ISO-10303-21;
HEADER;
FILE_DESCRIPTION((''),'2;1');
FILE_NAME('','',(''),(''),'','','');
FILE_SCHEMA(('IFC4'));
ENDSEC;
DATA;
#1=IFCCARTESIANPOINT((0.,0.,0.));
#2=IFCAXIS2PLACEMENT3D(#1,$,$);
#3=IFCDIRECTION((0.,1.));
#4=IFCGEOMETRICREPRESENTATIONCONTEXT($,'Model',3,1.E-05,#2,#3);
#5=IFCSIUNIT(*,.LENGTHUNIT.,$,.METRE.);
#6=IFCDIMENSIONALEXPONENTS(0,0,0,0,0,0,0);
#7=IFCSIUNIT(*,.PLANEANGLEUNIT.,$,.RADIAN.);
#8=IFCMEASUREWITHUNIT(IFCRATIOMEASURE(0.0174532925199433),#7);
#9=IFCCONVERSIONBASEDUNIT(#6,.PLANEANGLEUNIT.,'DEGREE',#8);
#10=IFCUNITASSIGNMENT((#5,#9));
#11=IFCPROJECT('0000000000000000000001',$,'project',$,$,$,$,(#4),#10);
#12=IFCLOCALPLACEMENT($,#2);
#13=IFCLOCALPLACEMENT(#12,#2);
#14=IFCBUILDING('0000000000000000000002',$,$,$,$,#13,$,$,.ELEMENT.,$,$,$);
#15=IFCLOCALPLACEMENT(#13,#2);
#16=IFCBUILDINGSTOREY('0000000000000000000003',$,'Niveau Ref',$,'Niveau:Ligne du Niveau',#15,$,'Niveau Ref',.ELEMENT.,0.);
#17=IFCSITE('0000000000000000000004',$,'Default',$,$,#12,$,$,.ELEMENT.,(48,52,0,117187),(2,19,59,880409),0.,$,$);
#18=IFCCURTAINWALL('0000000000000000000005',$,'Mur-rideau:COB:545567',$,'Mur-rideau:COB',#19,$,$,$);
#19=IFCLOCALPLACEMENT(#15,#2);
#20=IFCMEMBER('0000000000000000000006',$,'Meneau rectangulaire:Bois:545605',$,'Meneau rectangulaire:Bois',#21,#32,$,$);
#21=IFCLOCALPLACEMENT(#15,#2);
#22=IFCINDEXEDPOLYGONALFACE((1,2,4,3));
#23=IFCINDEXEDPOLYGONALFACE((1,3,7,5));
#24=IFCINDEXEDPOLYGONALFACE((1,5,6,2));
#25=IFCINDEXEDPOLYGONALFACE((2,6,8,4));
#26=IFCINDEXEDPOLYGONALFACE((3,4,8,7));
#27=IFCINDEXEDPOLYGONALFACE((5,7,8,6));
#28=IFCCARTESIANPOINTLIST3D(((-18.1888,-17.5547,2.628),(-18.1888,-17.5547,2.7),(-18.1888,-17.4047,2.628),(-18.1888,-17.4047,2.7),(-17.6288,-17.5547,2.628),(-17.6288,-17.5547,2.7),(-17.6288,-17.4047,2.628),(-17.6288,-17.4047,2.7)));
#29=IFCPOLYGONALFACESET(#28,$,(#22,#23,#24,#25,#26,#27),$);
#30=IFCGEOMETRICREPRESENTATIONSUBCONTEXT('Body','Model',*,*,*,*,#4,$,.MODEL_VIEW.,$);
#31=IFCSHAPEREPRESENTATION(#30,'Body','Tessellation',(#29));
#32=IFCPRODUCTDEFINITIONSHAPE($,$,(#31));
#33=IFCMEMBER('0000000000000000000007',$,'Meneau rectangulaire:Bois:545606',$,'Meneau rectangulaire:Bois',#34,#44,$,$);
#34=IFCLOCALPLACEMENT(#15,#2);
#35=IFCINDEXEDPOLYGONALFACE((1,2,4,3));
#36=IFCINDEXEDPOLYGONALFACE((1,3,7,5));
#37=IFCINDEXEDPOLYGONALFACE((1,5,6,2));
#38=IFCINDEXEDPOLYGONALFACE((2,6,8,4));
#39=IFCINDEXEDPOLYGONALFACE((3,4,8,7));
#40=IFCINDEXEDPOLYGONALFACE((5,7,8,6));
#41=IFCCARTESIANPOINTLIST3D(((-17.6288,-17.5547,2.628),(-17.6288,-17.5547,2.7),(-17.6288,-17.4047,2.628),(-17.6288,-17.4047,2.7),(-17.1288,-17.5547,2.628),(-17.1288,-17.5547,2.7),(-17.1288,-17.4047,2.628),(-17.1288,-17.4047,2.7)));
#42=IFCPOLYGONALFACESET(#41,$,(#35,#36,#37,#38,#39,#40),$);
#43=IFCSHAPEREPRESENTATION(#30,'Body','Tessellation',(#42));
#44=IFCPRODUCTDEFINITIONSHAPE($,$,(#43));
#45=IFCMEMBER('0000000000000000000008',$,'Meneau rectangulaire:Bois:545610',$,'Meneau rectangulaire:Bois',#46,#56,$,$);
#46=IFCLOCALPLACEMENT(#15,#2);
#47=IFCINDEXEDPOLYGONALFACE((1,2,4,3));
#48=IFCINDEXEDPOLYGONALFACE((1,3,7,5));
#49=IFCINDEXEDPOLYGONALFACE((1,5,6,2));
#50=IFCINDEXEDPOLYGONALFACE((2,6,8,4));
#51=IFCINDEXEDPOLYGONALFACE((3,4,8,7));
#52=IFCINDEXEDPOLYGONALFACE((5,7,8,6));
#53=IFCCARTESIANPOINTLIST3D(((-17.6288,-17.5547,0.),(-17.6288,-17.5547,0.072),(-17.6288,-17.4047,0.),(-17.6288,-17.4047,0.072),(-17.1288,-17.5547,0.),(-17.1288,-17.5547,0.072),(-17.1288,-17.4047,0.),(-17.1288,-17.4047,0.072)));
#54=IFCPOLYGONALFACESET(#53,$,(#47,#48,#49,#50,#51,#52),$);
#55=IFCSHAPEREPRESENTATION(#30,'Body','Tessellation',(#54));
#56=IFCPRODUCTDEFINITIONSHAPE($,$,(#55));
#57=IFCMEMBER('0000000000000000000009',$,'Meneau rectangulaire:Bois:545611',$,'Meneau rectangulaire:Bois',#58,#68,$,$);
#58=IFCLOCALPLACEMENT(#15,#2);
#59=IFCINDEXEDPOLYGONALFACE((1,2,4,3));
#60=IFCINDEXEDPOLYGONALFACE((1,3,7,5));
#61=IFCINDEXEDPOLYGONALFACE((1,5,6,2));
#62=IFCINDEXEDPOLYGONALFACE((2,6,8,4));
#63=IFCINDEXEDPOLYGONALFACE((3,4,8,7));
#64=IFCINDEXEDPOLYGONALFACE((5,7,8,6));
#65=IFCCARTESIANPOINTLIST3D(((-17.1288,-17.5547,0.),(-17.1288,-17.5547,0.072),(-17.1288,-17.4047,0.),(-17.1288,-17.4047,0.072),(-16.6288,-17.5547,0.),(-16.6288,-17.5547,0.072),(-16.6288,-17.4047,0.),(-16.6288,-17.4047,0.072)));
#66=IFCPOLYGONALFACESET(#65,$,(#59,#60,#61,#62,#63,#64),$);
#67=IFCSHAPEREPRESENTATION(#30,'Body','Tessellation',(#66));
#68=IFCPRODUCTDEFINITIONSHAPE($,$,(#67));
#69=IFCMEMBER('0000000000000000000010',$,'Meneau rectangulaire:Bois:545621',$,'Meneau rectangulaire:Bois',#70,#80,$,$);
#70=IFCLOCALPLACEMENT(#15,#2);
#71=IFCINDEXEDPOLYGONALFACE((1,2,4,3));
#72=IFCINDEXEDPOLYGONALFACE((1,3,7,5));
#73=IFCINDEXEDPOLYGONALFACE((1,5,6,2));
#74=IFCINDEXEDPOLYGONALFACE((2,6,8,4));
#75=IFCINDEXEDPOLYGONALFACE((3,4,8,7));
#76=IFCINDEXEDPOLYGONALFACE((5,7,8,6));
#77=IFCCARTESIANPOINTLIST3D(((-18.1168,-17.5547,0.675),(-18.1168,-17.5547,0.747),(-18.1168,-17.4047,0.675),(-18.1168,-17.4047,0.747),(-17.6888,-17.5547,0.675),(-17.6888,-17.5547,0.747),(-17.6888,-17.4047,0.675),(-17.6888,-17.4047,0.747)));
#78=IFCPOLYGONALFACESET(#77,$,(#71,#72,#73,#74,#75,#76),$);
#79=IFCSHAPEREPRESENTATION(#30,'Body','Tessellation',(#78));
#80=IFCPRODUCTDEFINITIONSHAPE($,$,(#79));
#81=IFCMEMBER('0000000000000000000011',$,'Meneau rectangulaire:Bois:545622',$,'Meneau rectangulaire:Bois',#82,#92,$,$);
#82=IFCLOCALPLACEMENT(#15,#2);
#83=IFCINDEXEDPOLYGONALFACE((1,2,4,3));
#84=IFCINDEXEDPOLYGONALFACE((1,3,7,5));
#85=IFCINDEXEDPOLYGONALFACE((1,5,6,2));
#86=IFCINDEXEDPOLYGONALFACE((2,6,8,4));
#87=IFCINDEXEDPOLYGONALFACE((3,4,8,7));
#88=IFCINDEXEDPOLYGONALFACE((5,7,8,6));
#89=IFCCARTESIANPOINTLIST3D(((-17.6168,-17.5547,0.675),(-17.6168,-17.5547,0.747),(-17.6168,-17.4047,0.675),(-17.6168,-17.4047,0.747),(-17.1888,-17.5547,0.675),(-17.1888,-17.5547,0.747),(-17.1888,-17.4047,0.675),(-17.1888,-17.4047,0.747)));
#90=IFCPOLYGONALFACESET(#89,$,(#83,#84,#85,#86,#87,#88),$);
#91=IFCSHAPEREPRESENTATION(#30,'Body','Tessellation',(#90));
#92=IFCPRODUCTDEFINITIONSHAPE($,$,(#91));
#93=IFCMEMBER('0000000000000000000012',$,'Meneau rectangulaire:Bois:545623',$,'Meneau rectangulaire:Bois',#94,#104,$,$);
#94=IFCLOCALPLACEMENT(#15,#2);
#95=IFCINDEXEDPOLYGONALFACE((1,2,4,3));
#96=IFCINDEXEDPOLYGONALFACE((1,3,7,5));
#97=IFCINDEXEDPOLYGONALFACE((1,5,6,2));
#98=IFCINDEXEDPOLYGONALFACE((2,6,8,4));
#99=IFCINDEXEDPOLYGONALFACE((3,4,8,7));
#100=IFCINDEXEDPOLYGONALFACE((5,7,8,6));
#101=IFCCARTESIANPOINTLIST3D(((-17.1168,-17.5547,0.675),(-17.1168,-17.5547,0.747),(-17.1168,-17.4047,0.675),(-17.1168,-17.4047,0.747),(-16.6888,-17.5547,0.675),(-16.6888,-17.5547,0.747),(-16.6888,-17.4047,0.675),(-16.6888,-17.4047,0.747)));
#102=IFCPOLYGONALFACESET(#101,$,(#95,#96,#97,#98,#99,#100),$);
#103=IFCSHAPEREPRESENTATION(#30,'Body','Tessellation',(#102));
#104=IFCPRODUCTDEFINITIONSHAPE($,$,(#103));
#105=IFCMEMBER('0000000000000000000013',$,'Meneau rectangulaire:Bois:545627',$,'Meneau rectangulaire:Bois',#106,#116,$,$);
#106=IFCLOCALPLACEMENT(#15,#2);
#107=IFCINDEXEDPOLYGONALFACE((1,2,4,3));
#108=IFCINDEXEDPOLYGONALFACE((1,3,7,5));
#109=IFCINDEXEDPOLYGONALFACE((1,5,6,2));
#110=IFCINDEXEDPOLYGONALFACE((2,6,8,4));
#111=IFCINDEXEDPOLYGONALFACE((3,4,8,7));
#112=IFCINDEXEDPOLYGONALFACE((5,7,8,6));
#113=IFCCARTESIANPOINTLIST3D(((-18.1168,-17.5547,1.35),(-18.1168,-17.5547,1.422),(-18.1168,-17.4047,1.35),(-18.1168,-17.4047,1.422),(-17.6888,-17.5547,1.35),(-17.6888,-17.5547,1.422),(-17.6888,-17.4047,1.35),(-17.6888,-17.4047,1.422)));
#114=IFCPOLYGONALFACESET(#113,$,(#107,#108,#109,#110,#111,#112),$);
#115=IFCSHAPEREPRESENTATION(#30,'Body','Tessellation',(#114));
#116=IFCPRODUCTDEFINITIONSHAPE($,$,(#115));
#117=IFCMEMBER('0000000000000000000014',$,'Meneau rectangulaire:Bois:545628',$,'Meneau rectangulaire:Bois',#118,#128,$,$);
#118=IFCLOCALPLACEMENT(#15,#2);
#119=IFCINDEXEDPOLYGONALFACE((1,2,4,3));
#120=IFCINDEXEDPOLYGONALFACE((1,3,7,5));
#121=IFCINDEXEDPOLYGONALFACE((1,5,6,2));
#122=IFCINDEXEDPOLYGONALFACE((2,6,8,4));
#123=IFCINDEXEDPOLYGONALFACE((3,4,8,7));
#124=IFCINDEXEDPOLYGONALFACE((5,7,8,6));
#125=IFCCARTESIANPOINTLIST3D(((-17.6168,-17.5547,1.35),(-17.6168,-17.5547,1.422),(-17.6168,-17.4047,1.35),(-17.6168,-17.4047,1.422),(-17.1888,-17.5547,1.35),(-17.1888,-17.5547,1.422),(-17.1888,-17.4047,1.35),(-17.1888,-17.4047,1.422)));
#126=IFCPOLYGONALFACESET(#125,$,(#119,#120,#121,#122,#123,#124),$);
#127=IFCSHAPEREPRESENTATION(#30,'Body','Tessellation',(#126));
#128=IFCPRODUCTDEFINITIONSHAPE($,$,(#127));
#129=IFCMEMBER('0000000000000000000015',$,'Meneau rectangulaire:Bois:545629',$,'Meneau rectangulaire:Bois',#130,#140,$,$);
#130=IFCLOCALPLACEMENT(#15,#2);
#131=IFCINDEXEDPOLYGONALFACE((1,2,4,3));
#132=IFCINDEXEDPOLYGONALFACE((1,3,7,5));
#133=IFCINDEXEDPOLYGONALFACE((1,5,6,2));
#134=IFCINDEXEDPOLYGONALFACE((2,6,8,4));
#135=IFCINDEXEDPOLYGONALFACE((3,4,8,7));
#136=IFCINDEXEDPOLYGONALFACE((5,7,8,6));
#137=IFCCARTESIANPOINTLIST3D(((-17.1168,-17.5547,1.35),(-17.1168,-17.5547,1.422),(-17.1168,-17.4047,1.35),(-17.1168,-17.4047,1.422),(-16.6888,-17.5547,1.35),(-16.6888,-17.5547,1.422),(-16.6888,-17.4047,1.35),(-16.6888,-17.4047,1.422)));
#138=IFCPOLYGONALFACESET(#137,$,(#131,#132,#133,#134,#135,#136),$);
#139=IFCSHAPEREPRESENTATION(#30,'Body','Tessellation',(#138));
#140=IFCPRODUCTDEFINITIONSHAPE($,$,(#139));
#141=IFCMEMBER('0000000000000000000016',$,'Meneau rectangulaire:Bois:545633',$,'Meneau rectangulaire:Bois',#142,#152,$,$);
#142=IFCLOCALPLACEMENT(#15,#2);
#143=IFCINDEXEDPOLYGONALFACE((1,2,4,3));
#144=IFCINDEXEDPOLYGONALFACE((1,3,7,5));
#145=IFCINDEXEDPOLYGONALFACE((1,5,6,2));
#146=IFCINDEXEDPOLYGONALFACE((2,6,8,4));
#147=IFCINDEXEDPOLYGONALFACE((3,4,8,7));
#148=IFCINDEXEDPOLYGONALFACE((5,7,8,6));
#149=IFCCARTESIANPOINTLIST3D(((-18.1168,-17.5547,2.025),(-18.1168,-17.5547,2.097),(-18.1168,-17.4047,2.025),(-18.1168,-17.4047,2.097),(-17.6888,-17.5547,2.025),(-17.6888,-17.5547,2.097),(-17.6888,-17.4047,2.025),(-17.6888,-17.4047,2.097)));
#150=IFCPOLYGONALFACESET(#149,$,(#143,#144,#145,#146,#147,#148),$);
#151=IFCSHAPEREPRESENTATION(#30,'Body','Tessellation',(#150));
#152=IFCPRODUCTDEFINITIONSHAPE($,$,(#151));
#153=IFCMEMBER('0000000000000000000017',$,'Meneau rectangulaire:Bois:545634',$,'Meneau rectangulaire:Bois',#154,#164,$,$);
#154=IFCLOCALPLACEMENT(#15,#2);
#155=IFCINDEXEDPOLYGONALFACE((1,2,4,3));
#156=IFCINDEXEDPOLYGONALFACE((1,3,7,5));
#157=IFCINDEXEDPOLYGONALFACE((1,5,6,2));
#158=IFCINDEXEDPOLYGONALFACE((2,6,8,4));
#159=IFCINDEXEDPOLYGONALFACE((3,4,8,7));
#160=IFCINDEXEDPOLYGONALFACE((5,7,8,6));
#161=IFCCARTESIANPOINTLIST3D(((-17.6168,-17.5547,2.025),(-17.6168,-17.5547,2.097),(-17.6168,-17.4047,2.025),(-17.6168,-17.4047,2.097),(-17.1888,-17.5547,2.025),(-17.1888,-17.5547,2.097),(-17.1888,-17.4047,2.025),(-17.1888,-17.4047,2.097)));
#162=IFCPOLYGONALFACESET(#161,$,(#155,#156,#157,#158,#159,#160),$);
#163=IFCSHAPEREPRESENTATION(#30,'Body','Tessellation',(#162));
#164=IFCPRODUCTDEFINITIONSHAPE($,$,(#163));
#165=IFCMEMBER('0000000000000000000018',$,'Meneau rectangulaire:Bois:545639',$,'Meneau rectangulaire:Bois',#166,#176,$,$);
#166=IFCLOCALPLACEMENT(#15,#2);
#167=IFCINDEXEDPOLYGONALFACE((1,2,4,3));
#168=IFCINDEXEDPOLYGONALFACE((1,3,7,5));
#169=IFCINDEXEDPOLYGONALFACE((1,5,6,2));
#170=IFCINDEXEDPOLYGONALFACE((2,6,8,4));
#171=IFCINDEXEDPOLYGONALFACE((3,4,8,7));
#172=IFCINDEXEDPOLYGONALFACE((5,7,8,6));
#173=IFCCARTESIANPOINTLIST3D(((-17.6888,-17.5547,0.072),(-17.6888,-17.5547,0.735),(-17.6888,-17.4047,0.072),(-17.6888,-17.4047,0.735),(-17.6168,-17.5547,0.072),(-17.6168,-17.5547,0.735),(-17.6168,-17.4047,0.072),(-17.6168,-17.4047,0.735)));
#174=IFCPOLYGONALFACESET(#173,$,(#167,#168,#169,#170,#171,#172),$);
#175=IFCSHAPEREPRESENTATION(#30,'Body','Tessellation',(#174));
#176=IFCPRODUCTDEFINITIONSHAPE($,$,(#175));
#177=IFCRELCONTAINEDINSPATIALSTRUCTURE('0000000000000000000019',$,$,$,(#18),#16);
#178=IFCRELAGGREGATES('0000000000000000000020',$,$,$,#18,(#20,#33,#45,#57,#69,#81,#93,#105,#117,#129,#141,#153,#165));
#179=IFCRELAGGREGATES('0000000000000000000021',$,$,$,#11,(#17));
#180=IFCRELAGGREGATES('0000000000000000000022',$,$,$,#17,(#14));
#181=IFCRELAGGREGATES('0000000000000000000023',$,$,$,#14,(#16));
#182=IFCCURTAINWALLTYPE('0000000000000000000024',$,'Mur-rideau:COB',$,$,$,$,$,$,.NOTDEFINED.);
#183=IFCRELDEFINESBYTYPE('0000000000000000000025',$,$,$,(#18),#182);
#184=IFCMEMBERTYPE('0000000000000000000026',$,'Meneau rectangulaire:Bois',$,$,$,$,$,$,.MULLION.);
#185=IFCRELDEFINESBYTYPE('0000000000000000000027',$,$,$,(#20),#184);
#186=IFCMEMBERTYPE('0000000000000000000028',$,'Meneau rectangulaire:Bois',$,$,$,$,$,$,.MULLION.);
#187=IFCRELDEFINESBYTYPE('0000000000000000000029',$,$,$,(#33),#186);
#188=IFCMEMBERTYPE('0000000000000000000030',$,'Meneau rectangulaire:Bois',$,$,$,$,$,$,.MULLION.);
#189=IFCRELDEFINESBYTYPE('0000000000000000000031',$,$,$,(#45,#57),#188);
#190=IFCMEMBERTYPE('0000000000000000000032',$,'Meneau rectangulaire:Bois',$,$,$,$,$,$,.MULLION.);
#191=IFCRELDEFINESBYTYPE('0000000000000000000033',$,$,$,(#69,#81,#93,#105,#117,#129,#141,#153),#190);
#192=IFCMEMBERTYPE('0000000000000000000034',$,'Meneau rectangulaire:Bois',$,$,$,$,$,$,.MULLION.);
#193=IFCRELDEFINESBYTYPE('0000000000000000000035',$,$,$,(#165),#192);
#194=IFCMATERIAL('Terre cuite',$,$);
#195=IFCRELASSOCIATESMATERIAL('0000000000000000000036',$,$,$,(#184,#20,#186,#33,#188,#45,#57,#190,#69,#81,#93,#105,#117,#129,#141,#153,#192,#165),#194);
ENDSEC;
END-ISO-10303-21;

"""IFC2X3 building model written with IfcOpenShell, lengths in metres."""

from ifc_helpers import new_model, entity, si_unit, converted_unit, direction, frame, origin, origin_2d_with_axis, place, context, subcontext, project, spatial, rectangle, extrude, source, transform, mapped, material, type_object, type_shapes, element, aggregate, save


model = new_model("IFC2X3")

# Units and contexts
model_context = context("Model", 3, precision=1e-05, world=origin(), true_north=direction((0.0, 1.0)))
body_context = subcontext(model_context, "Body", "Model", "MODEL_VIEW")
ifc_project = project(units=[si_unit("LENGTHUNIT", "METRE"), converted_unit("PLANEANGLEUNIT", "DEGREE", entity("IfcRatioMeasure", 0.0174532925199433), si_unit("PLANEANGLEUNIT", "RADIAN"), dimensions=[0, 0, 0, 0, 0, 0, 0])], contexts=[model_context])

# Site, building, storey
site_placement = place(None, origin())
site = spatial("IfcSite", under=ifc_project, at=site_placement, Name="Default", CompositionType="ELEMENT", RefLatitude=(48, 52, 0, 117187), RefLongitude=(2, 19, 59, 880409), RefElevation=0.0)
building_placement = place(site_placement, origin())
building = spatial("IfcBuilding", under=site, at=building_placement, CompositionType="ELEMENT")
storey_placement = place(building_placement, origin())
storey = spatial("IfcBuildingStorey", under=building, at=storey_placement, Name="Niveau Ref", ObjectType="Niveau:Ligne du Niveau", LongName="Niveau Ref", CompositionType="ELEMENT", Elevation=0.0)

# Curtain wall, members
curtain_wall_type_1 = type_object("IfcCurtainWallType", Name="Mur-rideau:COB", PredefinedType="NOTDEFINED")
curtain_wall_1_placement = place(storey_placement, origin())
curtain_wall_1 = element("IfcCurtainWall", 1, at=curtain_wall_1_placement, inside=storey, type_object=curtain_wall_type_1, Name="Mur-rideau:COB:545567", ObjectType="Mur-rideau:COB")
ifc_material_1 = material(Name="Terre cuite")
member_type_1 = type_object("IfcMemberType", Name="Meneau rectangulaire:Bois", PredefinedType="MULLION", material=ifc_material_1)
shared_shape_1 = source(origin(), body_context, "Body", "SweptSolid", [
    extrude(rectangle(XDim=0.15, YDim=0.072, at=origin_2d_with_axis()), frame((-0.036, 0.0, -0.56), z_axis=(0.0, 0.0, 1.0), x_axis=(0.0, -1.0, 0.0)), (0.0, 0.0, 1.0), 0.56),
])
type_shapes(member_type_1, [shared_shape_1])
member_1_placement = place(storey_placement, frame((-17.6288, -17.4797, 2.7), z_axis=(1.0, 0.0, 0.0), x_axis=(0.0, 0.0, 1.0)))
member_1 = element("IfcMember", 2, at=member_1_placement, type_object=member_type_1, material=ifc_material_1, Name="Meneau rectangulaire:Bois:545605", ObjectType="Meneau rectangulaire:Bois", context=body_context, shape_type="MappedRepresentation", body=[
    mapped(shared_shape_1, transform((0.0, 0.0, 0.0), scale=1.0)),
])
member_type_2 = type_object("IfcMemberType", Name="Meneau rectangulaire:Bois", PredefinedType="MULLION", material=ifc_material_1)
shared_shape_2 = source(origin(), body_context, "Body", "SweptSolid", [
    extrude(rectangle(XDim=0.15, YDim=0.072, at=origin_2d_with_axis()), frame((-0.036, 0.0, -0.5), z_axis=(0.0, 0.0, 1.0), x_axis=(0.0, -1.0, 0.0)), (0.0, 0.0, 1.0), 0.5),
])
type_shapes(member_type_2, [shared_shape_2])
member_2_placement = place(storey_placement, frame((-17.1288, -17.4797, 2.7), z_axis=(1.0, 0.0, 0.0), x_axis=(0.0, 0.0, 1.0)))
member_2 = element("IfcMember", 3, at=member_2_placement, type_object=member_type_2, material=ifc_material_1, Name="Meneau rectangulaire:Bois:545606", ObjectType="Meneau rectangulaire:Bois", context=body_context, shape_type="MappedRepresentation", body=[
    mapped(shared_shape_2, transform((0.0, 0.0, 0.0), scale=1.0)),
])
member_type_3 = type_object("IfcMemberType", Name="Meneau rectangulaire:Bois", PredefinedType="MULLION", material=ifc_material_1)
shared_shape_3 = source(origin(), body_context, "Body", "SweptSolid", [
    extrude(rectangle(XDim=0.15, YDim=0.072, at=origin_2d_with_axis()), frame((-0.036, 0.0, -0.5), z_axis=(0.0, 0.0, 1.0), x_axis=(0.0, -1.0, 0.0)), (0.0, 0.0, 1.0), 0.5),
])
type_shapes(member_type_3, [shared_shape_3])
member_3_placement = place(storey_placement, frame((-17.6288, -17.4797, 0.0), z_axis=(-1.0, 0.0, 0.0), x_axis=(0.0, 0.0, -1.0)))
member_3 = element("IfcMember", 4, at=member_3_placement, type_object=member_type_3, material=ifc_material_1, Name="Meneau rectangulaire:Bois:545610", ObjectType="Meneau rectangulaire:Bois", context=body_context, shape_type="MappedRepresentation", body=[
    mapped(shared_shape_3, transform((0.0, 0.0, 0.0), scale=1.0)),
])
member_4_placement = place(storey_placement, frame((-17.1288, -17.4797, 0.0), z_axis=(-1.0, 0.0, 0.0), x_axis=(0.0, 0.0, -1.0)))
member_4 = element("IfcMember", 5, at=member_4_placement, type_object=member_type_3, material=ifc_material_1, Name="Meneau rectangulaire:Bois:545611", ObjectType="Meneau rectangulaire:Bois", context=body_context, shape_type="MappedRepresentation", body=[
    mapped(shared_shape_3, transform((0.0, 0.0, 0.0), scale=1.0)),
])
member_type_4 = type_object("IfcMemberType", Name="Meneau rectangulaire:Bois", PredefinedType="MULLION", material=ifc_material_1)
shared_shape_4 = source(origin(), body_context, "Body", "SweptSolid", [
    extrude(rectangle(XDim=0.15, YDim=0.072, at=origin_2d_with_axis()), frame((-0.024, 0.0, -0.428), z_axis=(0.0, 0.0, 1.0), x_axis=(0.0, -1.0, 0.0)), (0.0, 0.0, 1.0), 0.428),
])
type_shapes(member_type_4, [shared_shape_4])
member_5_placement = place(storey_placement, frame((-17.6888, -17.4797, 0.735), z_axis=(1.0, 0.0, 0.0), x_axis=(0.0, 0.0, 1.0)))
member_5 = element("IfcMember", 6, at=member_5_placement, type_object=member_type_4, material=ifc_material_1, Name="Meneau rectangulaire:Bois:545621", ObjectType="Meneau rectangulaire:Bois", context=body_context, shape_type="MappedRepresentation", body=[
    mapped(shared_shape_4, transform((0.0, 0.0, 0.0), scale=1.0)),
])
member_6_placement = place(storey_placement, frame((-17.1888, -17.4797, 0.735), z_axis=(1.0, 0.0, 0.0), x_axis=(0.0, 0.0, 1.0)))
member_6 = element("IfcMember", 7, at=member_6_placement, type_object=member_type_4, material=ifc_material_1, Name="Meneau rectangulaire:Bois:545622", ObjectType="Meneau rectangulaire:Bois", context=body_context, shape_type="MappedRepresentation", body=[
    mapped(shared_shape_4, transform((0.0, 0.0, 0.0), scale=1.0)),
])
member_7_placement = place(storey_placement, frame((-16.6888, -17.4797, 0.735), z_axis=(1.0, 0.0, 0.0), x_axis=(0.0, 0.0, 1.0)))
member_7 = element("IfcMember", 8, at=member_7_placement, type_object=member_type_4, material=ifc_material_1, Name="Meneau rectangulaire:Bois:545623", ObjectType="Meneau rectangulaire:Bois", context=body_context, shape_type="MappedRepresentation", body=[
    mapped(shared_shape_4, transform((0.0, 0.0, 0.0), scale=1.0)),
])
member_8_placement = place(storey_placement, frame((-17.6888, -17.4797, 1.41), z_axis=(1.0, 0.0, 0.0), x_axis=(0.0, 0.0, 1.0)))
member_8 = element("IfcMember", 9, at=member_8_placement, type_object=member_type_4, material=ifc_material_1, Name="Meneau rectangulaire:Bois:545627", ObjectType="Meneau rectangulaire:Bois", context=body_context, shape_type="MappedRepresentation", body=[
    mapped(shared_shape_4, transform((0.0, 0.0, 0.0), scale=1.0)),
])
member_9_placement = place(storey_placement, frame((-17.1888, -17.4797, 1.41), z_axis=(1.0, 0.0, 0.0), x_axis=(0.0, 0.0, 1.0)))
member_9 = element("IfcMember", 10, at=member_9_placement, type_object=member_type_4, material=ifc_material_1, Name="Meneau rectangulaire:Bois:545628", ObjectType="Meneau rectangulaire:Bois", context=body_context, shape_type="MappedRepresentation", body=[
    mapped(shared_shape_4, transform((0.0, 0.0, 0.0), scale=1.0)),
])
member_10_placement = place(storey_placement, frame((-16.6888, -17.4797, 1.41), z_axis=(1.0, 0.0, 0.0), x_axis=(0.0, 0.0, 1.0)))
member_10 = element("IfcMember", 11, at=member_10_placement, type_object=member_type_4, material=ifc_material_1, Name="Meneau rectangulaire:Bois:545629", ObjectType="Meneau rectangulaire:Bois", context=body_context, shape_type="MappedRepresentation", body=[
    mapped(shared_shape_4, transform((0.0, 0.0, 0.0), scale=1.0)),
])
member_11_placement = place(storey_placement, frame((-17.6888, -17.4797, 2.085), z_axis=(1.0, 0.0, 0.0), x_axis=(0.0, 0.0, 1.0)))
member_11 = element("IfcMember", 12, at=member_11_placement, type_object=member_type_4, material=ifc_material_1, Name="Meneau rectangulaire:Bois:545633", ObjectType="Meneau rectangulaire:Bois", context=body_context, shape_type="MappedRepresentation", body=[
    mapped(shared_shape_4, transform((0.0, 0.0, 0.0), scale=1.0)),
])
member_12_placement = place(storey_placement, frame((-17.1888, -17.4797, 2.085), z_axis=(1.0, 0.0, 0.0), x_axis=(0.0, 0.0, 1.0)))
member_12 = element("IfcMember", 13, at=member_12_placement, type_object=member_type_4, material=ifc_material_1, Name="Meneau rectangulaire:Bois:545634", ObjectType="Meneau rectangulaire:Bois", context=body_context, shape_type="MappedRepresentation", body=[
    mapped(shared_shape_4, transform((0.0, 0.0, 0.0), scale=1.0)),
])
member_type_5 = type_object("IfcMemberType", Name="Meneau rectangulaire:Bois", PredefinedType="MULLION", material=ifc_material_1)
shared_shape_5 = source(origin(), body_context, "Body", "SweptSolid", [
    extrude(rectangle(XDim=0.15, YDim=0.072, at=origin_2d_with_axis()), frame((-0.024, 0.0, -0.663), z_axis=(0.0, 0.0, 1.0), x_axis=(0.0, -1.0, 0.0)), (0.0, 0.0, 1.0), 0.663),
])
type_shapes(member_type_5, [shared_shape_5])
member_13_placement = place(storey_placement, frame((-17.6288, -17.4797, 0.072), z_axis=(0.0, 0.0, -1.0), x_axis=(1.0, 0.0, 0.0)))
member_13 = element("IfcMember", 14, at=member_13_placement, type_object=member_type_5, material=ifc_material_1, Name="Meneau rectangulaire:Bois:545639", ObjectType="Meneau rectangulaire:Bois", context=body_context, shape_type="MappedRepresentation", body=[
    mapped(shared_shape_5, transform((0.0, 0.0, 0.0), scale=1.0)),
])
aggregate(curtain_wall_1, [member_1, member_2, member_3, member_4, member_5, member_6, member_7, member_8, member_9, member_10, member_11, member_12, member_13])

save(model, "model.ifc")
